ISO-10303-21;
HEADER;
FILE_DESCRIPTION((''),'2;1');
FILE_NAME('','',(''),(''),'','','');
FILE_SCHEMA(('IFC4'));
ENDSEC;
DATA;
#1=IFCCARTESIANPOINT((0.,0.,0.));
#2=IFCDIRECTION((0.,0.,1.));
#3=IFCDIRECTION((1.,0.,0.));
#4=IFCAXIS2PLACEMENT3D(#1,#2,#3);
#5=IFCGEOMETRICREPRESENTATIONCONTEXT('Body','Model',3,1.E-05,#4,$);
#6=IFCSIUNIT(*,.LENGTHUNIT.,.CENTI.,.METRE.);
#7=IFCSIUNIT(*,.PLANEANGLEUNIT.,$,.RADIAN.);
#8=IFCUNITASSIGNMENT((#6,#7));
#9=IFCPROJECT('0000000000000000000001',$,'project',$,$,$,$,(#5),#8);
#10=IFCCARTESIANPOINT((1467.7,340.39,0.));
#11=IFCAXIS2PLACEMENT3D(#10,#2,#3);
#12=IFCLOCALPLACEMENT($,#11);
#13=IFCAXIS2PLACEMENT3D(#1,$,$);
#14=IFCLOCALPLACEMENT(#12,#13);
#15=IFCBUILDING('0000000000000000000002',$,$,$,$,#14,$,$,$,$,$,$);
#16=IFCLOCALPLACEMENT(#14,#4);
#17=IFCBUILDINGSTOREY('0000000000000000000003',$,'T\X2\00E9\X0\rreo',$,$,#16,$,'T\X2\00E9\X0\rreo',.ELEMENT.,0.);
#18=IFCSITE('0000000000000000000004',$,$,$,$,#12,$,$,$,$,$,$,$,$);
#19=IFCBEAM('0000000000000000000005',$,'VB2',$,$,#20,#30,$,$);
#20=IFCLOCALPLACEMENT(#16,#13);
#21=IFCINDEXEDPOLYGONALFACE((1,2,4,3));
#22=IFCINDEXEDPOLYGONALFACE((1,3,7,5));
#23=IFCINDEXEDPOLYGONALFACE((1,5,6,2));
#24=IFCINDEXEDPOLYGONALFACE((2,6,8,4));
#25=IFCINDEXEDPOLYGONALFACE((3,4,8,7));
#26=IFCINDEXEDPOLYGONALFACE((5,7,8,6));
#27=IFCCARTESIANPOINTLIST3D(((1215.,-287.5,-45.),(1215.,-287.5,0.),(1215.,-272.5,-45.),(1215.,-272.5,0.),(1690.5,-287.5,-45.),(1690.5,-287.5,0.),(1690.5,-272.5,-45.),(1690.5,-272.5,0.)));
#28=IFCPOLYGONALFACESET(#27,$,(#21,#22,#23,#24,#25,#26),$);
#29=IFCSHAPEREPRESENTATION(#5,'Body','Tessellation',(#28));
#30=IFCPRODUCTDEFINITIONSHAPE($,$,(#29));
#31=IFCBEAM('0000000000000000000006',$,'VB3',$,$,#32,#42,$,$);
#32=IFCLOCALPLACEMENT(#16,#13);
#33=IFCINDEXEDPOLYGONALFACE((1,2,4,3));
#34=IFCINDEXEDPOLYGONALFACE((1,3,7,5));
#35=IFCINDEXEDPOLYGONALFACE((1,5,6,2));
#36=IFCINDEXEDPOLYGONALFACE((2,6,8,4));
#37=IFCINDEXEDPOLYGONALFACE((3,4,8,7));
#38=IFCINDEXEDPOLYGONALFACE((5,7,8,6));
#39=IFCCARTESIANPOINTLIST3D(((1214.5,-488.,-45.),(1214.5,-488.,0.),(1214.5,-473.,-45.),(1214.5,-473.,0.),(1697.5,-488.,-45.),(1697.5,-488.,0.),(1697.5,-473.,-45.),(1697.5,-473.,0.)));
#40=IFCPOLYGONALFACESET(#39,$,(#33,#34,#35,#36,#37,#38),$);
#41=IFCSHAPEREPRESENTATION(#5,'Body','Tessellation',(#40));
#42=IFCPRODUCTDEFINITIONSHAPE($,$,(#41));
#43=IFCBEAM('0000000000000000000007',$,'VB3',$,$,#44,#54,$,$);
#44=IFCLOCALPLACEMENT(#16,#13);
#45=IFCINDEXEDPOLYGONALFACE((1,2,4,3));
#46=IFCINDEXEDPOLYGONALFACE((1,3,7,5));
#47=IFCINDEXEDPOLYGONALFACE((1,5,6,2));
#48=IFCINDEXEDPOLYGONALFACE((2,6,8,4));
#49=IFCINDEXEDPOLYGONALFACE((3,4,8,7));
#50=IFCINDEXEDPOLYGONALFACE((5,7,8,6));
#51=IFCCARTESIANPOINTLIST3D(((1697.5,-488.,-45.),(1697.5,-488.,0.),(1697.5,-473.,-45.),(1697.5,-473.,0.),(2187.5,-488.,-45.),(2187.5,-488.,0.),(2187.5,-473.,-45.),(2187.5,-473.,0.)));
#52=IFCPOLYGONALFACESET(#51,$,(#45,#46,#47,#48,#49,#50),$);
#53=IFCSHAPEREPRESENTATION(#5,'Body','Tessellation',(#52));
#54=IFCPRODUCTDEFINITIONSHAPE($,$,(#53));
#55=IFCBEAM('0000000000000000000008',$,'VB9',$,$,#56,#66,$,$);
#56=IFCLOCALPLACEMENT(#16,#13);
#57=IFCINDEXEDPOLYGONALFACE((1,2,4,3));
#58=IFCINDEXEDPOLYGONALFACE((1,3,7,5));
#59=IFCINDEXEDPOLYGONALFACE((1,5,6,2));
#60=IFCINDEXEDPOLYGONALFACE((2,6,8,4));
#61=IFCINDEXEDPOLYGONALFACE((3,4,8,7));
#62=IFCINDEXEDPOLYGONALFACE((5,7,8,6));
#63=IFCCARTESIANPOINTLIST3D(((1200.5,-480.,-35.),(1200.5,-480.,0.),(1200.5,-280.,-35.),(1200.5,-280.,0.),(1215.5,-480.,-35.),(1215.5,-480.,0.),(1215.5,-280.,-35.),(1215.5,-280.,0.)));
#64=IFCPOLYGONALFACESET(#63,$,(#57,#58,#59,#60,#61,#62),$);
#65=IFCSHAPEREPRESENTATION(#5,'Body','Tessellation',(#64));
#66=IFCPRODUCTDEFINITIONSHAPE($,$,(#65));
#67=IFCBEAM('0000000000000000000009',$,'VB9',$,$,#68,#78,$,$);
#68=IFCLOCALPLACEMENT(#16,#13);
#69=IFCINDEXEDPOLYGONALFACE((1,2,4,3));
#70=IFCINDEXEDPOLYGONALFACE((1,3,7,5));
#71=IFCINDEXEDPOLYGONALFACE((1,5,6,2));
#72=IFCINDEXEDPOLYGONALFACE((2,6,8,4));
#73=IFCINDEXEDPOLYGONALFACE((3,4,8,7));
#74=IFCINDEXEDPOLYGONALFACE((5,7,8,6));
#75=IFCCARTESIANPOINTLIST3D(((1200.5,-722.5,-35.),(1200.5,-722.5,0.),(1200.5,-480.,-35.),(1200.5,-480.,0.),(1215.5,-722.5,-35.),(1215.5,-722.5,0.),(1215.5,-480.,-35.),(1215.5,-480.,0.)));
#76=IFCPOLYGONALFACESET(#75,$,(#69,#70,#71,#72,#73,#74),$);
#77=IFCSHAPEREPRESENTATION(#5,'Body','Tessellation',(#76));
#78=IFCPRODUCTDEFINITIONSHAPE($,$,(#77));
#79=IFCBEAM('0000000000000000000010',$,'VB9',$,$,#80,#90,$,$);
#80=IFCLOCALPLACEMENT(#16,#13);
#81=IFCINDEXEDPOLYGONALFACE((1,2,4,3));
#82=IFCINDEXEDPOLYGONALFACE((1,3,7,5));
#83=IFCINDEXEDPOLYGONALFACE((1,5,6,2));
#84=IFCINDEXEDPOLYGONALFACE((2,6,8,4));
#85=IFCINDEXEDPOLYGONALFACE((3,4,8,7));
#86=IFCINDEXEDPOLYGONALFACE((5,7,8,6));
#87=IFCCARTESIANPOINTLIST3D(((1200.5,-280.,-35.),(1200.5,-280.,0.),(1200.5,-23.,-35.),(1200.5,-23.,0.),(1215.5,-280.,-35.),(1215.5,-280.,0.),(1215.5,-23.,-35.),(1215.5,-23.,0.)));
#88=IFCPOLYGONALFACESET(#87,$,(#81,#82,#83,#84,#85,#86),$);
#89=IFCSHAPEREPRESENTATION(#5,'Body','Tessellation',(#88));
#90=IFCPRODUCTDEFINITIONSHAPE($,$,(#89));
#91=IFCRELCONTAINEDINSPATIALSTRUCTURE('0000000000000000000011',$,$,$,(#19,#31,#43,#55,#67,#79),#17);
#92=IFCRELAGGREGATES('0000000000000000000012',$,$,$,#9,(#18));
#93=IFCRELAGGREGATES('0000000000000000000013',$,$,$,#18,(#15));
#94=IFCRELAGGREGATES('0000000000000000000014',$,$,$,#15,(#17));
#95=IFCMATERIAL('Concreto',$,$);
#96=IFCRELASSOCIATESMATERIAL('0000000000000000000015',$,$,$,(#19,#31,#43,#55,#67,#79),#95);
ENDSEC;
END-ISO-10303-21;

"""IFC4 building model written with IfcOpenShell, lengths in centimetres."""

from ifc_helpers import new_model, si_unit, frame, origin, origin_with_axes, origin_2d_with_axis, place, context, project, spatial, rectangle, extrude, material, element, save


model = new_model("IFC4")

# Units and contexts
model_context = context("Model", 3, precision=1e-05, world=origin_with_axes(), identifier="Body")
ifc_project = project(units=[si_unit("LENGTHUNIT", "METRE", prefix="CENTI"), si_unit("PLANEANGLEUNIT", "RADIAN")], contexts=[model_context])

# Site, building, storey
site_placement = place(None, frame((1467.7, 340.39, 0.0), z_axis=(0.0, 0.0, 1.0), x_axis=(1.0, 0.0, 0.0)))
site = spatial("IfcSite", under=ifc_project, at=site_placement)
building_placement = place(site_placement, origin())
building = spatial("IfcBuilding", under=site, at=building_placement)
storey_placement = place(building_placement, origin_with_axes())
storey = spatial("IfcBuildingStorey", under=building, at=storey_placement, Name="Térreo", LongName="Térreo", CompositionType="ELEMENT", Elevation=0.0)

# Shared definitions
ifc_material = material(Name="Concreto")

# Beams
beam_1_placement = place(storey_placement, frame((1452.75, -280.0, 0.0), z_axis=(0.0, 0.0, 1.0), x_axis=(1.0, 0.0, 0.0)))
element("IfcBeam", 1, at=beam_1_placement, inside=storey, material=ifc_material, Name="VB2", context=model_context, shape_type="SolidModel", body=[
    extrude(rectangle(XDim=15.0, YDim=45.0, at=origin_2d_with_axis()), frame((-237.75, 0.0, -22.5), z_axis=(1.0, 0.0, 0.0), x_axis=(0.0, 1.0, 0.0)), (0.0, 0.0, 1.0), 475.5),
])
beam_2_placement = place(storey_placement, frame((1456.0, -480.5, 0.0), z_axis=(0.0, 0.0, 1.0), x_axis=(1.0, 0.0, 0.0)))
element("IfcBeam", 2, at=beam_2_placement, inside=storey, material=ifc_material, Name="VB3", context=model_context, shape_type="SolidModel", body=[
    extrude(rectangle(XDim=15.0, YDim=45.0, at=origin_2d_with_axis()), frame((-241.5, 0.0, -22.5), z_axis=(1.0, 0.0, 0.0), x_axis=(0.0, 1.0, 0.0)), (0.0, 0.0, 1.0), 483.0),
])
beam_3_placement = place(storey_placement, frame((1942.5, -480.5, 0.0), z_axis=(0.0, 0.0, 1.0), x_axis=(1.0, 0.0, 0.0)))
element("IfcBeam", 3, at=beam_3_placement, inside=storey, material=ifc_material, Name="VB3", context=model_context, shape_type="SolidModel", body=[
    extrude(rectangle(XDim=15.0, YDim=45.0, at=origin_2d_with_axis()), frame((-245.0, 0.0, -22.5), z_axis=(1.0, 0.0, 0.0), x_axis=(0.0, 1.0, 0.0)), (0.0, 0.0, 1.0), 490.0),
])
beam_4_placement = place(storey_placement, frame((1208.0, -380.0, 0.0), z_axis=(0.0, 0.0, 1.0), x_axis=(1.0, 0.0, 0.0)))
element("IfcBeam", 4, at=beam_4_placement, inside=storey, material=ifc_material, Name="VB9", context=model_context, shape_type="SolidModel", body=[
    extrude(rectangle(XDim=15.0, YDim=35.0, at=origin_2d_with_axis()), frame((0.0, -100.0, -17.5), z_axis=(0.0, 1.0, 0.0), x_axis=(1.0, 0.0, 0.0)), (0.0, 0.0, 1.0), 200.0),
])
beam_5_placement = place(storey_placement, frame((1208.0, -601.25, 0.0), z_axis=(0.0, 0.0, 1.0), x_axis=(1.0, 0.0, 0.0)))
element("IfcBeam", 5, at=beam_5_placement, inside=storey, material=ifc_material, Name="VB9", context=model_context, shape_type="SolidModel", body=[
    extrude(rectangle(XDim=15.0, YDim=35.0, at=origin_2d_with_axis()), frame((0.0, -121.25, -17.5), z_axis=(0.0, 1.0, 0.0), x_axis=(1.0, 0.0, 0.0)), (0.0, 0.0, 1.0), 242.5),
])
beam_6_placement = place(storey_placement, frame((1208.0, -151.5, 0.0), z_axis=(0.0, 0.0, 1.0), x_axis=(1.0, 0.0, 0.0)))
element("IfcBeam", 6, at=beam_6_placement, inside=storey, material=ifc_material, Name="VB9", context=model_context, shape_type="SolidModel", body=[
    extrude(rectangle(XDim=15.0, YDim=35.0, at=origin_2d_with_axis()), frame((0.0, -128.5, -17.5), z_axis=(0.0, 1.0, 0.0), x_axis=(1.0, 0.0, 0.0)), (0.0, 0.0, 1.0), 257.0),
])

save(model, "model.ifc")
